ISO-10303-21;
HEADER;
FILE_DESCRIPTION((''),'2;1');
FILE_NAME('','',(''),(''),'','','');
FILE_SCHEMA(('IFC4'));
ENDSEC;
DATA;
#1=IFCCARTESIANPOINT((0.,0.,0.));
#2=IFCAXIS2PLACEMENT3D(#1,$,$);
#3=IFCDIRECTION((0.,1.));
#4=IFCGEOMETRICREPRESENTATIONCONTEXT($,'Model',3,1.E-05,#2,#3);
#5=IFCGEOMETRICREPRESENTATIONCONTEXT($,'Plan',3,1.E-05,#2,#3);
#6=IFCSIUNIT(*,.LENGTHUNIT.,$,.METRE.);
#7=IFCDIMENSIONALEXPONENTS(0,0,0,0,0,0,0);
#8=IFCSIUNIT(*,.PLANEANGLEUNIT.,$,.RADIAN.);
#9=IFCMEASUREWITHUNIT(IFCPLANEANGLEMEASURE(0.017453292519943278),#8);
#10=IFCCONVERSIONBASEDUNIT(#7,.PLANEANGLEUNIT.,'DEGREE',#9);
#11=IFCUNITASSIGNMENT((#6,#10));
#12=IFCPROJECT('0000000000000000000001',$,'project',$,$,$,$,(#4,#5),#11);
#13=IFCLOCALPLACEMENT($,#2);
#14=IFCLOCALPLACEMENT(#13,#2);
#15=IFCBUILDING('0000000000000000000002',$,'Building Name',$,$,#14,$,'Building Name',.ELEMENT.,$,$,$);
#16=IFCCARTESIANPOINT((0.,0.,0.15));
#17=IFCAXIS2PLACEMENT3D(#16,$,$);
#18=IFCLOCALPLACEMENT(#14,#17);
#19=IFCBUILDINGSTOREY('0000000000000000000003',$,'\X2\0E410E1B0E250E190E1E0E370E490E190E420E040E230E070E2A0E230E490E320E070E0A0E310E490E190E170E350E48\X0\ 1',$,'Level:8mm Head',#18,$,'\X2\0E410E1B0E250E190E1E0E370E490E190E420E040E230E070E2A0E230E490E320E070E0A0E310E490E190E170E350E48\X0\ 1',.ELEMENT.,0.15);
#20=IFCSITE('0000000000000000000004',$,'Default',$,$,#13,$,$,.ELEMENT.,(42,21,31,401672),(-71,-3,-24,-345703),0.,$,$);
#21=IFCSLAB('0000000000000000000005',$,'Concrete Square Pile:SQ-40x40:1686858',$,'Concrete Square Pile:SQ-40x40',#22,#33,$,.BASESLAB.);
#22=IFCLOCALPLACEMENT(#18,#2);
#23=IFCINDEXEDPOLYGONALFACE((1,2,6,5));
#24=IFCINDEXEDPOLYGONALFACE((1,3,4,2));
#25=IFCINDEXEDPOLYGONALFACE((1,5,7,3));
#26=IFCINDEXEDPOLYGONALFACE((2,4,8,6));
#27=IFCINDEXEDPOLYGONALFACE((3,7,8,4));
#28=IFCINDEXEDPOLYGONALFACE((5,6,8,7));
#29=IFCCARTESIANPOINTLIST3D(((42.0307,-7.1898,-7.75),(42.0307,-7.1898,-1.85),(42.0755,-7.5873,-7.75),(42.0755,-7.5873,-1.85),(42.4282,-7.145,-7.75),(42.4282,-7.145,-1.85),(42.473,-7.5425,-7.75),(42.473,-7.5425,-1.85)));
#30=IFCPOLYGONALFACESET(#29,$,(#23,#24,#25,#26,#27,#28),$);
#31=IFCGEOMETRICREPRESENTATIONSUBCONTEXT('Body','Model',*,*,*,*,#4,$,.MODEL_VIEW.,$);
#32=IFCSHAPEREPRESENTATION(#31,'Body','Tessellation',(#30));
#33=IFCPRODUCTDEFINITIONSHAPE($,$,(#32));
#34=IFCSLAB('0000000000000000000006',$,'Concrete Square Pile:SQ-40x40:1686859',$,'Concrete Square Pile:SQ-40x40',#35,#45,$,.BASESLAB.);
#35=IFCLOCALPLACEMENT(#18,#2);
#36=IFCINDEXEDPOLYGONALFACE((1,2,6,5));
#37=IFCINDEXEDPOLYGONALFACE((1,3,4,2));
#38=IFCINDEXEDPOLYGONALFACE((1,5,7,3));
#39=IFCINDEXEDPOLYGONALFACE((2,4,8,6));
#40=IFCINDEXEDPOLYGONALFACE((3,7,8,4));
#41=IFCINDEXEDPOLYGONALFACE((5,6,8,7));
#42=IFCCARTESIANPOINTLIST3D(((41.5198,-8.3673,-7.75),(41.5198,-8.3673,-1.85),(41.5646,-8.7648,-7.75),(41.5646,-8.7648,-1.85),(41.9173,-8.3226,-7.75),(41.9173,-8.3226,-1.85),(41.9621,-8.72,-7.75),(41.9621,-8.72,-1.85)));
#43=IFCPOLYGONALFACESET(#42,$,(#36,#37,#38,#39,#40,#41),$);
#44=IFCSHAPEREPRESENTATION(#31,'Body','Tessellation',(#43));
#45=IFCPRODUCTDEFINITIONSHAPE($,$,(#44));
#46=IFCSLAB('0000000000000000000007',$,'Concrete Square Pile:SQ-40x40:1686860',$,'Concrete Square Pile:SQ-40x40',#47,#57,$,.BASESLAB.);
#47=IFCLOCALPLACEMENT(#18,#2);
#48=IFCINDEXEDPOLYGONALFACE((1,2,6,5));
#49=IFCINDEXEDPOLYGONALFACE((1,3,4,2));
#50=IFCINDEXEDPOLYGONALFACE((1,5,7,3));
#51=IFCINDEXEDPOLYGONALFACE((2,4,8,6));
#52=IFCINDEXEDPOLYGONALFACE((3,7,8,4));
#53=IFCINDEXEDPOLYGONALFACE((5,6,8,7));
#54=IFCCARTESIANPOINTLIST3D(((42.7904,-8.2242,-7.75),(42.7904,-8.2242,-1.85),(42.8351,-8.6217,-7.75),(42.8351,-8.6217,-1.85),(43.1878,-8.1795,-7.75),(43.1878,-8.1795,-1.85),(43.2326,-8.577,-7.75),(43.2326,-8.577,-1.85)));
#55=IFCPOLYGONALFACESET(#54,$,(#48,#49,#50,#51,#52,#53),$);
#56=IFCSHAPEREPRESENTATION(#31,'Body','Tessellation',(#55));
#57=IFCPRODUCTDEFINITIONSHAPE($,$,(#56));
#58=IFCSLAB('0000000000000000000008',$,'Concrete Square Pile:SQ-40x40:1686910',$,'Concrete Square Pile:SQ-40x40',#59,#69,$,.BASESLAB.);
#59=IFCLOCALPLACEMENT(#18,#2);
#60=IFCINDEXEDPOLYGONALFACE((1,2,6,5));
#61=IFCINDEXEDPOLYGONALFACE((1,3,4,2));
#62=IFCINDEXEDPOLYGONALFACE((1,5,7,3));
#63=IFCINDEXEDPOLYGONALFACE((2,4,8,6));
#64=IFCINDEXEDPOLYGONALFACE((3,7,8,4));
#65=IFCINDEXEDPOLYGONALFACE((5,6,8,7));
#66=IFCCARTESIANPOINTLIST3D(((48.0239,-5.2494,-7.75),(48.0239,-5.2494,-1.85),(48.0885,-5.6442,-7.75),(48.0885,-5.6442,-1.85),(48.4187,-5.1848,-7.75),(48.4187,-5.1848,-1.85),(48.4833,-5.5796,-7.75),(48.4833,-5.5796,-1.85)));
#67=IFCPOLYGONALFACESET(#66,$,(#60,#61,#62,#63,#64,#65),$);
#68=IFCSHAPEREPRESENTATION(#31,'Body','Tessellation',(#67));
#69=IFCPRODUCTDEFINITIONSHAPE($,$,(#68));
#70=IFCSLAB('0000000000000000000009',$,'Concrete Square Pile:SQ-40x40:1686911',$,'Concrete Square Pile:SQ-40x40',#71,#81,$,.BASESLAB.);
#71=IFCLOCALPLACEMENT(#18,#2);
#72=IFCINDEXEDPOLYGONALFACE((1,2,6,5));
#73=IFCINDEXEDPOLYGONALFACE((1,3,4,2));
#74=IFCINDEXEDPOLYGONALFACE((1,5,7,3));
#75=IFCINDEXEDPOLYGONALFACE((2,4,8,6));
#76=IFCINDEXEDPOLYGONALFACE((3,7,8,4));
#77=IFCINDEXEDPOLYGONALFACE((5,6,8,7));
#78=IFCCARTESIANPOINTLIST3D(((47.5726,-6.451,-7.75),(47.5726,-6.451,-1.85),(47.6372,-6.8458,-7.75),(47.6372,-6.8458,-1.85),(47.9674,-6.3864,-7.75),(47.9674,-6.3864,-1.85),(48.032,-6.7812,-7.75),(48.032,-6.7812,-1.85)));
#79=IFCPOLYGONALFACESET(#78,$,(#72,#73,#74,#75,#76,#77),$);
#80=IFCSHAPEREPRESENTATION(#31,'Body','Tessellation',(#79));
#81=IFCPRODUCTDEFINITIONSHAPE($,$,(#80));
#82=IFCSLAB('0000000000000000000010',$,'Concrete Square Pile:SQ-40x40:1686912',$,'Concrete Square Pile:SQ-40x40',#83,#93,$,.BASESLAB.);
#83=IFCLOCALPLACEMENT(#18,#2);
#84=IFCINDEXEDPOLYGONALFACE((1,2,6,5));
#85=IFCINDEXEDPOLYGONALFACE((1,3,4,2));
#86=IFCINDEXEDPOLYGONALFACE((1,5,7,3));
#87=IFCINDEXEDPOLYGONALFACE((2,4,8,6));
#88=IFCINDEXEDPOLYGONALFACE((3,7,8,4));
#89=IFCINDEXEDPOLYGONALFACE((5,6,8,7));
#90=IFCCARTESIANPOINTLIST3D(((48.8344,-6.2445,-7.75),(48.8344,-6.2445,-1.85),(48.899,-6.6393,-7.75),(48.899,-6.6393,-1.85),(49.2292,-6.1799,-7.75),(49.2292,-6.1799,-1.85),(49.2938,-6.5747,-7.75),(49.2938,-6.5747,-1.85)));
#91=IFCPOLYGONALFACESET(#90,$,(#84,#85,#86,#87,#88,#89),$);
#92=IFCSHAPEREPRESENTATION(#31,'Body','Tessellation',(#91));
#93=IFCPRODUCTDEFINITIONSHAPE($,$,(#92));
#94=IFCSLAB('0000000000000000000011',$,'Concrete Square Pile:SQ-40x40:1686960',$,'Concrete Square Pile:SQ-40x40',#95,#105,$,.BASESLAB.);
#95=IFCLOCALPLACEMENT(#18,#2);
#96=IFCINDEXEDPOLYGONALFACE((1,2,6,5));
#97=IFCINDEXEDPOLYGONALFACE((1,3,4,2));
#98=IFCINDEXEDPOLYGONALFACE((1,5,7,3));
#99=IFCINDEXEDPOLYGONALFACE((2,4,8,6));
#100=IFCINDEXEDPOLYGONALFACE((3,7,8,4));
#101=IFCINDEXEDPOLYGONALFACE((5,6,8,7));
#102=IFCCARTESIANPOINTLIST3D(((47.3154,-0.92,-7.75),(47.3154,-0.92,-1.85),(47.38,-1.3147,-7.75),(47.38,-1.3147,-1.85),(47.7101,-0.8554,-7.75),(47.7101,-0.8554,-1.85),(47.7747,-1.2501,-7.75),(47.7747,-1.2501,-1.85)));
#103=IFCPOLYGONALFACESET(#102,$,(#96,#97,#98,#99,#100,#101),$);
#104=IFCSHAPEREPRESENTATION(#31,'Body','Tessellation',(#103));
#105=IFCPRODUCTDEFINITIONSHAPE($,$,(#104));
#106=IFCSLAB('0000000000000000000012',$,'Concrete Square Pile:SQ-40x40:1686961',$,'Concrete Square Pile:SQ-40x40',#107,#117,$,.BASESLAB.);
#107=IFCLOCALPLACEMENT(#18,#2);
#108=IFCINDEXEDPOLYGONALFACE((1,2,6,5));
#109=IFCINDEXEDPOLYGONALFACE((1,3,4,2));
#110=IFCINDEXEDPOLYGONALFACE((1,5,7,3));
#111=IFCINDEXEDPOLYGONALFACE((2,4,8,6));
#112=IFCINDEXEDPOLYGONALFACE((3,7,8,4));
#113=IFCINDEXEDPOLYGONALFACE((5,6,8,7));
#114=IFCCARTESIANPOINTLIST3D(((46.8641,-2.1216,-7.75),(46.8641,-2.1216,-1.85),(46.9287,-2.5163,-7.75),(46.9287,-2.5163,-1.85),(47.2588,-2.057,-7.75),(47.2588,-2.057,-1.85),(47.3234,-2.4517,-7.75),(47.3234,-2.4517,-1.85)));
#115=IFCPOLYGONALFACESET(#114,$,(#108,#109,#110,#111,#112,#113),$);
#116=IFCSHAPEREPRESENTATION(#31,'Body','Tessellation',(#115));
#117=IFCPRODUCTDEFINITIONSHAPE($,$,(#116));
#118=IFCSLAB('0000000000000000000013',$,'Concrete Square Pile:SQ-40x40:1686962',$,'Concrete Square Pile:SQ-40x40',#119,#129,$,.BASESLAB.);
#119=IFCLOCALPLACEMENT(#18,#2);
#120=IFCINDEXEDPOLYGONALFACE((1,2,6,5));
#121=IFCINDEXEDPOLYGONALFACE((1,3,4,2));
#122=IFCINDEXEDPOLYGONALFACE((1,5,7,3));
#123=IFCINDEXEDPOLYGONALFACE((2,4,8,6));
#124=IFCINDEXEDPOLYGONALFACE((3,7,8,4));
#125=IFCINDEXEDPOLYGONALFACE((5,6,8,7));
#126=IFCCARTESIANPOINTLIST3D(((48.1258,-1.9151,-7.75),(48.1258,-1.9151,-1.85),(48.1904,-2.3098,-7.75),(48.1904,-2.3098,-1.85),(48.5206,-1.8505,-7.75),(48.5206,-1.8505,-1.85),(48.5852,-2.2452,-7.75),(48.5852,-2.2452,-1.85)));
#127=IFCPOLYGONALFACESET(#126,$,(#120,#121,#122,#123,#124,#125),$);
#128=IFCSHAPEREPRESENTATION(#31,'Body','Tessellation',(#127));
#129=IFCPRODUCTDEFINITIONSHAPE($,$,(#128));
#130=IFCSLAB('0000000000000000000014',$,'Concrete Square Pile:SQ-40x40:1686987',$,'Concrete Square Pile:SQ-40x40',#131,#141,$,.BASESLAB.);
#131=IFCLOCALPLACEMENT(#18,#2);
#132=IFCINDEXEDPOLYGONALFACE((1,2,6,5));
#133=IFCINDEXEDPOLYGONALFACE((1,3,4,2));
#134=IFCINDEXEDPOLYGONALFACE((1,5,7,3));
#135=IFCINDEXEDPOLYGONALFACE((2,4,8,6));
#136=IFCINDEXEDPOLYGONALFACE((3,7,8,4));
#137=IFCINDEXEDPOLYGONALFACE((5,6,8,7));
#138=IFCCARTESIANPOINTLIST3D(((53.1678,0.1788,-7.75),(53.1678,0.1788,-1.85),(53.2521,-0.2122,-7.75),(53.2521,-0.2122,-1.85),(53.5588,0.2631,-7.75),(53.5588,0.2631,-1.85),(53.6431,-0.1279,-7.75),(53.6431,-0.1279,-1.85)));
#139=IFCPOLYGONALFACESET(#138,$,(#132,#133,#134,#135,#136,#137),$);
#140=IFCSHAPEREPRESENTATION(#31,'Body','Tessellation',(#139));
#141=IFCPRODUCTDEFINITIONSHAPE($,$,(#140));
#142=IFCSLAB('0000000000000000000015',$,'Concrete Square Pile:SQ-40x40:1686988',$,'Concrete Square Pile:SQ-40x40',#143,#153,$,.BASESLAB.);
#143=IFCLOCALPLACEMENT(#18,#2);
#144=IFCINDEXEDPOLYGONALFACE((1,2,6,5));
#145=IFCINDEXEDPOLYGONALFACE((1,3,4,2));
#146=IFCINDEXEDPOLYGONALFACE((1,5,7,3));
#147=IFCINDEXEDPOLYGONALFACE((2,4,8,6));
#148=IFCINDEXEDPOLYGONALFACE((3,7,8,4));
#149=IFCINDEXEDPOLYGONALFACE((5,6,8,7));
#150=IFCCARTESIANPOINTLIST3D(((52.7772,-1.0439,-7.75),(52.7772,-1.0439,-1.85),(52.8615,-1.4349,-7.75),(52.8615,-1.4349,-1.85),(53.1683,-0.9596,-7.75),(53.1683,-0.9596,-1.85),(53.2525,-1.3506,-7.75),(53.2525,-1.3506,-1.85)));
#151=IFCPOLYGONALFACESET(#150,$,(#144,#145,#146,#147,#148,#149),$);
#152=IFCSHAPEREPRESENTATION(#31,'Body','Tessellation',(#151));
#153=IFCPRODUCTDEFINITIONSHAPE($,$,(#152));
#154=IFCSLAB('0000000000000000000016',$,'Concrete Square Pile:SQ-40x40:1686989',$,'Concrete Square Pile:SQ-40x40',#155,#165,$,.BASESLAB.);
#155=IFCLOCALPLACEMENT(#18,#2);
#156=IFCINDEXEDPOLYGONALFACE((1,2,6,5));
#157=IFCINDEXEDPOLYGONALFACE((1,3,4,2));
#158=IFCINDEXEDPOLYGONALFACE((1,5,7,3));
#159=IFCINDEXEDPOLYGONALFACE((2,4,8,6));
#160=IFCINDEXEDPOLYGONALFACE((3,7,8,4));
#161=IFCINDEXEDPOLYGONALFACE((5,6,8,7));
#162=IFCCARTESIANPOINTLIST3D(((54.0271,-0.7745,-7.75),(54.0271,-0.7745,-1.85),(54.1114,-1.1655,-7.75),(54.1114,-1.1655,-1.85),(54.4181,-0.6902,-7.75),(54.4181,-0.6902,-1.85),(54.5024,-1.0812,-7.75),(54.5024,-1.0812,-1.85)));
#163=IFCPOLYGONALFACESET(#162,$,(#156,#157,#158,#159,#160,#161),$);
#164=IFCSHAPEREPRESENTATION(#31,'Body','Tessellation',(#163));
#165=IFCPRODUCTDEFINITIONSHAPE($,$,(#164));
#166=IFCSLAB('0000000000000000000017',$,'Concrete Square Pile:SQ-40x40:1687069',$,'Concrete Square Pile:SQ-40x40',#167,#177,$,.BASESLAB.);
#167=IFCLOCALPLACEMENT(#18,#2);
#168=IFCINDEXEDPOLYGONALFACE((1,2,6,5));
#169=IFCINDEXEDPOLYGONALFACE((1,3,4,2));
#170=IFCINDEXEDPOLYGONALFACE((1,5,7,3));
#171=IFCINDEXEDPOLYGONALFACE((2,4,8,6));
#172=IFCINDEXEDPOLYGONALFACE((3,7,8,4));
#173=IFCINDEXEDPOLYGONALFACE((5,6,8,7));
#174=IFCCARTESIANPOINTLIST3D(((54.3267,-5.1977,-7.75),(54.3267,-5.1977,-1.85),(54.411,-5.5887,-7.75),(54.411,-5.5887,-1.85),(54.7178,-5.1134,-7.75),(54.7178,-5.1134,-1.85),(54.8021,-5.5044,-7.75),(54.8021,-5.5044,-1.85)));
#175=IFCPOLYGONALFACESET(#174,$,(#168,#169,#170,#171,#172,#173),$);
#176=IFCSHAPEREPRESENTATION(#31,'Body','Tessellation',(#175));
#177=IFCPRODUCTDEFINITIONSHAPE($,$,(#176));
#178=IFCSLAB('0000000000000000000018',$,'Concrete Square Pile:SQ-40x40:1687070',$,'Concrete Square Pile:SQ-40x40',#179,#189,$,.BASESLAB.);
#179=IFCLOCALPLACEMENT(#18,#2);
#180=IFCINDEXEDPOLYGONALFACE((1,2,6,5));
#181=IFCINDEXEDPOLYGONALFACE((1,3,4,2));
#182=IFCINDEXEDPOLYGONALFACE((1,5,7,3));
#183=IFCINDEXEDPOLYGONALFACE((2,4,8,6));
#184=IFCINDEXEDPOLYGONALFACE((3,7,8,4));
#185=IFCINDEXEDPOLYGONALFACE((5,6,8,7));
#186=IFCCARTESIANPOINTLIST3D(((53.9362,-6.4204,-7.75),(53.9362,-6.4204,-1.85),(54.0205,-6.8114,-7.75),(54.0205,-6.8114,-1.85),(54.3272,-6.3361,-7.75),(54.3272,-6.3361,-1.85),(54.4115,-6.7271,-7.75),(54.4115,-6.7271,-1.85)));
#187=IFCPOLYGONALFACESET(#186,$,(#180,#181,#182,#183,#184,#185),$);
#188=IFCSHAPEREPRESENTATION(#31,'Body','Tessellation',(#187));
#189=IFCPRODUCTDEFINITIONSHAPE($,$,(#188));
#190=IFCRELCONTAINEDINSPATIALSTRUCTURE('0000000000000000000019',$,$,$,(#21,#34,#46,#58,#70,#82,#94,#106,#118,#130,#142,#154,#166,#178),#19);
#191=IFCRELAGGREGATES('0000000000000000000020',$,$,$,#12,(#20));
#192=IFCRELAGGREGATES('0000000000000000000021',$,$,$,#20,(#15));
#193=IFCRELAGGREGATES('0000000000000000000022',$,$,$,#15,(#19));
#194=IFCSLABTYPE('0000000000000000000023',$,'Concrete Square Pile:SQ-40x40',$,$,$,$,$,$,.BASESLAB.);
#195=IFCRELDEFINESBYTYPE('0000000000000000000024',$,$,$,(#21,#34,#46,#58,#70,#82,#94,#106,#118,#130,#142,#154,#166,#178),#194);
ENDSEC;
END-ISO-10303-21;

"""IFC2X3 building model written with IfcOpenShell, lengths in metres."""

from ifc_helpers import new_model, entity, si_unit, converted_unit, direction, frame, frame_2d, origin, place, context, subcontext, project, spatial, rectangle, extrude, type_object, element, save


model = new_model("IFC2X3")

# Units and contexts
model_context = context("Model", 3, precision=1e-05, world=origin(), true_north=direction((0.0, 1.0)))
plan_context = context("Plan", 3, precision=1e-05, world=origin(), true_north=direction((0.0, 1.0)))
body_context = subcontext(model_context, "Body", "Model", "MODEL_VIEW")
ifc_project = project(units=[si_unit("LENGTHUNIT", "METRE"), converted_unit("PLANEANGLEUNIT", "DEGREE", entity("IfcPlaneAngleMeasure", 0.017453292519943278), si_unit("PLANEANGLEUNIT", "RADIAN"), dimensions=[0, 0, 0, 0, 0, 0, 0])], contexts=[model_context, plan_context])

# Site, building, storey
site_placement = place(None, origin())
site = spatial("IfcSite", under=ifc_project, at=site_placement, Name="Default", CompositionType="ELEMENT", RefLatitude=(42, 21, 31, 401672), RefLongitude=(-71, -3, -24, -345703), RefElevation=0.0)
building_placement = place(site_placement, origin())
building = spatial("IfcBuilding", under=site, at=building_placement, Name="Building Name", LongName="Building Name", CompositionType="ELEMENT")
storey_placement = place(building_placement, frame((0.0, 0.0, 0.15)))
storey = spatial("IfcBuildingStorey", under=building, at=storey_placement, Name="แปลนพื้นโครงสร้างชั้นที่ 1", ObjectType="Level:8mm Head", LongName="แปลนพื้นโครงสร้างชั้นที่ 1", CompositionType="ELEMENT", Elevation=0.15)

# Slabs
slab_type_1 = type_object("IfcSlabType", Name="Concrete Square Pile:SQ-40x40", PredefinedType="BASESLAB")
slab_1_placement = place(storey_placement, origin())
element("IfcSlab", 1, at=slab_1_placement, inside=storey, type_object=slab_type_1, Name="Concrete Square Pile:SQ-40x40:1686858", ObjectType="Concrete Square Pile:SQ-40x40", PredefinedType="BASESLAB", context=body_context, shape_type="SweptSolid", body=[
    extrude(rectangle(XDim=0.4, YDim=0.4, at=frame_2d((0.0, 0.0), x_axis=(1.0, 0.0))), frame((42.2518, -7.3662, -7.75), z_axis=(0.0, 0.0, 1.0), x_axis=(-0.993719, -0.111904, 0.0)), (0.0, 0.0, 1.0), 5.9),
])
slab_2_placement = place(storey_placement, origin())
element("IfcSlab", 2, at=slab_2_placement, inside=storey, type_object=slab_type_1, Name="Concrete Square Pile:SQ-40x40:1686859", ObjectType="Concrete Square Pile:SQ-40x40", PredefinedType="BASESLAB", context=body_context, shape_type="SweptSolid", body=[
    extrude(rectangle(XDim=0.4, YDim=0.4, at=frame_2d((0.0, 0.0), x_axis=(1.0, 0.0))), frame((41.7409, -8.5437, -7.75), z_axis=(0.0, 0.0, 1.0), x_axis=(-0.993719, -0.111904, 0.0)), (0.0, 0.0, 1.0), 5.9),
])
slab_3_placement = place(storey_placement, origin())
element("IfcSlab", 3, at=slab_3_placement, inside=storey, type_object=slab_type_1, Name="Concrete Square Pile:SQ-40x40:1686860", ObjectType="Concrete Square Pile:SQ-40x40", PredefinedType="BASESLAB", context=body_context, shape_type="SweptSolid", body=[
    extrude(rectangle(XDim=0.4, YDim=0.4, at=frame_2d((0.0, 0.0), x_axis=(1.0, 0.0))), frame((43.0115, -8.4006, -7.75), z_axis=(0.0, 0.0, 1.0), x_axis=(-0.993719, -0.111904, 0.0)), (0.0, 0.0, 1.0), 5.9),
])
slab_4_placement = place(storey_placement, origin())
element("IfcSlab", 4, at=slab_4_placement, inside=storey, type_object=slab_type_1, Name="Concrete Square Pile:SQ-40x40:1686910", ObjectType="Concrete Square Pile:SQ-40x40", PredefinedType="BASESLAB", context=body_context, shape_type="SweptSolid", body=[
    extrude(rectangle(XDim=0.4, YDim=0.4, at=frame_2d((0.0, 0.0), x_axis=(1.0, 0.0))), frame((48.2536, -5.4145, -7.75), z_axis=(0.0, 0.0, 1.0), x_axis=(-0.986871, -0.161513, 0.0)), (0.0, 0.0, 1.0), 5.9),
])
slab_5_placement = place(storey_placement, origin())
element("IfcSlab", 5, at=slab_5_placement, inside=storey, type_object=slab_type_1, Name="Concrete Square Pile:SQ-40x40:1686911", ObjectType="Concrete Square Pile:SQ-40x40", PredefinedType="BASESLAB", context=body_context, shape_type="SweptSolid", body=[
    extrude(rectangle(XDim=0.4, YDim=0.4, at=frame_2d((0.0, 0.0), x_axis=(1.0, 0.0))), frame((47.8023, -6.6161, -7.75), z_axis=(0.0, 0.0, 1.0), x_axis=(-0.986871, -0.161513, 0.0)), (0.0, 0.0, 1.0), 5.9),
])
slab_6_placement = place(storey_placement, origin())
element("IfcSlab", 6, at=slab_6_placement, inside=storey, type_object=slab_type_1, Name="Concrete Square Pile:SQ-40x40:1686912", ObjectType="Concrete Square Pile:SQ-40x40", PredefinedType="BASESLAB", context=body_context, shape_type="SweptSolid", body=[
    extrude(rectangle(XDim=0.4, YDim=0.4, at=frame_2d((0.0, 0.0), x_axis=(1.0, 0.0))), frame((49.0641, -6.4096, -7.75), z_axis=(0.0, 0.0, 1.0), x_axis=(-0.986871, -0.161513, 0.0)), (0.0, 0.0, 1.0), 5.9),
])
slab_7_placement = place(storey_placement, origin())
element("IfcSlab", 7, at=slab_7_placement, inside=storey, type_object=slab_type_1, Name="Concrete Square Pile:SQ-40x40:1686960", ObjectType="Concrete Square Pile:SQ-40x40", PredefinedType="BASESLAB", context=body_context, shape_type="SweptSolid", body=[
    extrude(rectangle(XDim=0.4, YDim=0.4, at=frame_2d((0.0, 0.0), x_axis=(1.0, 0.0))), frame((47.545, -1.085, -7.75), z_axis=(0.0, 0.0, 1.0), x_axis=(-0.986871, -0.161513, 0.0)), (0.0, 0.0, 1.0), 5.9),
])
slab_8_placement = place(storey_placement, origin())
element("IfcSlab", 8, at=slab_8_placement, inside=storey, type_object=slab_type_1, Name="Concrete Square Pile:SQ-40x40:1686961", ObjectType="Concrete Square Pile:SQ-40x40", PredefinedType="BASESLAB", context=body_context, shape_type="SweptSolid", body=[
    extrude(rectangle(XDim=0.4, YDim=0.4, at=frame_2d((0.0, 0.0), x_axis=(1.0, 0.0))), frame((47.0937, -2.2866, -7.75), z_axis=(0.0, 0.0, 1.0), x_axis=(-0.986871, -0.161513, 0.0)), (0.0, 0.0, 1.0), 5.9),
])
slab_9_placement = place(storey_placement, origin())
element("IfcSlab", 9, at=slab_9_placement, inside=storey, type_object=slab_type_1, Name="Concrete Square Pile:SQ-40x40:1686962", ObjectType="Concrete Square Pile:SQ-40x40", PredefinedType="BASESLAB", context=body_context, shape_type="SweptSolid", body=[
    extrude(rectangle(XDim=0.4, YDim=0.4, at=frame_2d((0.0, 0.0), x_axis=(1.0, 0.0))), frame((48.3555, -2.0801, -7.75), z_axis=(0.0, 0.0, 1.0), x_axis=(-0.986871, -0.161513, 0.0)), (0.0, 0.0, 1.0), 5.9),
])
slab_10_placement = place(storey_placement, origin())
element("IfcSlab", 10, at=slab_10_placement, inside=storey, type_object=slab_type_1, Name="Concrete Square Pile:SQ-40x40:1686987", ObjectType="Concrete Square Pile:SQ-40x40", PredefinedType="BASESLAB", context=body_context, shape_type="SweptSolid", body=[
    extrude(rectangle(XDim=0.4, YDim=0.4, at=frame_2d((0.0, 0.0), x_axis=(1.0, 0.0))), frame((53.4055, 0.0254, -7.75), z_axis=(0.0, 0.0, 1.0), x_axis=(-0.977547, -0.210717, 0.0)), (0.0, 0.0, 1.0), 5.9),
])
slab_11_placement = place(storey_placement, origin())
element("IfcSlab", 11, at=slab_11_placement, inside=storey, type_object=slab_type_1, Name="Concrete Square Pile:SQ-40x40:1686988", ObjectType="Concrete Square Pile:SQ-40x40", PredefinedType="BASESLAB", context=body_context, shape_type="SweptSolid", body=[
    extrude(rectangle(XDim=0.4, YDim=0.4, at=frame_2d((0.0, 0.0), x_axis=(1.0, 0.0))), frame((53.0149, -1.1973, -7.75), z_axis=(0.0, 0.0, 1.0), x_axis=(-0.977547, -0.210717, 0.0)), (0.0, 0.0, 1.0), 5.9),
])
slab_12_placement = place(storey_placement, origin())
element("IfcSlab", 12, at=slab_12_placement, inside=storey, type_object=slab_type_1, Name="Concrete Square Pile:SQ-40x40:1686989", ObjectType="Concrete Square Pile:SQ-40x40", PredefinedType="BASESLAB", context=body_context, shape_type="SweptSolid", body=[
    extrude(rectangle(XDim=0.4, YDim=0.4, at=frame_2d((0.0, 0.0), x_axis=(1.0, 0.0))), frame((54.2647, -0.9278, -7.75), z_axis=(0.0, 0.0, 1.0), x_axis=(-0.977547, -0.210717, 0.0)), (0.0, 0.0, 1.0), 5.9),
])
slab_13_placement = place(storey_placement, origin())
element("IfcSlab", 13, at=slab_13_placement, inside=storey, type_object=slab_type_1, Name="Concrete Square Pile:SQ-40x40:1687069", ObjectType="Concrete Square Pile:SQ-40x40", PredefinedType="BASESLAB", context=body_context, shape_type="SweptSolid", body=[
    extrude(rectangle(XDim=0.4, YDim=0.4, at=frame_2d((0.0, 0.0), x_axis=(1.0, 0.0))), frame((54.5644, -5.3511, -7.75), z_axis=(0.0, 0.0, 1.0), x_axis=(-0.977547, -0.210717, 0.0)), (0.0, 0.0, 1.0), 5.9),
])
slab_14_placement = place(storey_placement, origin())
element("IfcSlab", 14, at=slab_14_placement, inside=storey, type_object=slab_type_1, Name="Concrete Square Pile:SQ-40x40:1687070", ObjectType="Concrete Square Pile:SQ-40x40", PredefinedType="BASESLAB", context=body_context, shape_type="SweptSolid", body=[
    extrude(rectangle(XDim=0.4, YDim=0.4, at=frame_2d((0.0, 0.0), x_axis=(1.0, 0.0))), frame((54.1738, -6.5738, -7.75), z_axis=(0.0, 0.0, 1.0), x_axis=(-0.977547, -0.210717, 0.0)), (0.0, 0.0, 1.0), 5.9),
])

save(model, "model.ifc")
